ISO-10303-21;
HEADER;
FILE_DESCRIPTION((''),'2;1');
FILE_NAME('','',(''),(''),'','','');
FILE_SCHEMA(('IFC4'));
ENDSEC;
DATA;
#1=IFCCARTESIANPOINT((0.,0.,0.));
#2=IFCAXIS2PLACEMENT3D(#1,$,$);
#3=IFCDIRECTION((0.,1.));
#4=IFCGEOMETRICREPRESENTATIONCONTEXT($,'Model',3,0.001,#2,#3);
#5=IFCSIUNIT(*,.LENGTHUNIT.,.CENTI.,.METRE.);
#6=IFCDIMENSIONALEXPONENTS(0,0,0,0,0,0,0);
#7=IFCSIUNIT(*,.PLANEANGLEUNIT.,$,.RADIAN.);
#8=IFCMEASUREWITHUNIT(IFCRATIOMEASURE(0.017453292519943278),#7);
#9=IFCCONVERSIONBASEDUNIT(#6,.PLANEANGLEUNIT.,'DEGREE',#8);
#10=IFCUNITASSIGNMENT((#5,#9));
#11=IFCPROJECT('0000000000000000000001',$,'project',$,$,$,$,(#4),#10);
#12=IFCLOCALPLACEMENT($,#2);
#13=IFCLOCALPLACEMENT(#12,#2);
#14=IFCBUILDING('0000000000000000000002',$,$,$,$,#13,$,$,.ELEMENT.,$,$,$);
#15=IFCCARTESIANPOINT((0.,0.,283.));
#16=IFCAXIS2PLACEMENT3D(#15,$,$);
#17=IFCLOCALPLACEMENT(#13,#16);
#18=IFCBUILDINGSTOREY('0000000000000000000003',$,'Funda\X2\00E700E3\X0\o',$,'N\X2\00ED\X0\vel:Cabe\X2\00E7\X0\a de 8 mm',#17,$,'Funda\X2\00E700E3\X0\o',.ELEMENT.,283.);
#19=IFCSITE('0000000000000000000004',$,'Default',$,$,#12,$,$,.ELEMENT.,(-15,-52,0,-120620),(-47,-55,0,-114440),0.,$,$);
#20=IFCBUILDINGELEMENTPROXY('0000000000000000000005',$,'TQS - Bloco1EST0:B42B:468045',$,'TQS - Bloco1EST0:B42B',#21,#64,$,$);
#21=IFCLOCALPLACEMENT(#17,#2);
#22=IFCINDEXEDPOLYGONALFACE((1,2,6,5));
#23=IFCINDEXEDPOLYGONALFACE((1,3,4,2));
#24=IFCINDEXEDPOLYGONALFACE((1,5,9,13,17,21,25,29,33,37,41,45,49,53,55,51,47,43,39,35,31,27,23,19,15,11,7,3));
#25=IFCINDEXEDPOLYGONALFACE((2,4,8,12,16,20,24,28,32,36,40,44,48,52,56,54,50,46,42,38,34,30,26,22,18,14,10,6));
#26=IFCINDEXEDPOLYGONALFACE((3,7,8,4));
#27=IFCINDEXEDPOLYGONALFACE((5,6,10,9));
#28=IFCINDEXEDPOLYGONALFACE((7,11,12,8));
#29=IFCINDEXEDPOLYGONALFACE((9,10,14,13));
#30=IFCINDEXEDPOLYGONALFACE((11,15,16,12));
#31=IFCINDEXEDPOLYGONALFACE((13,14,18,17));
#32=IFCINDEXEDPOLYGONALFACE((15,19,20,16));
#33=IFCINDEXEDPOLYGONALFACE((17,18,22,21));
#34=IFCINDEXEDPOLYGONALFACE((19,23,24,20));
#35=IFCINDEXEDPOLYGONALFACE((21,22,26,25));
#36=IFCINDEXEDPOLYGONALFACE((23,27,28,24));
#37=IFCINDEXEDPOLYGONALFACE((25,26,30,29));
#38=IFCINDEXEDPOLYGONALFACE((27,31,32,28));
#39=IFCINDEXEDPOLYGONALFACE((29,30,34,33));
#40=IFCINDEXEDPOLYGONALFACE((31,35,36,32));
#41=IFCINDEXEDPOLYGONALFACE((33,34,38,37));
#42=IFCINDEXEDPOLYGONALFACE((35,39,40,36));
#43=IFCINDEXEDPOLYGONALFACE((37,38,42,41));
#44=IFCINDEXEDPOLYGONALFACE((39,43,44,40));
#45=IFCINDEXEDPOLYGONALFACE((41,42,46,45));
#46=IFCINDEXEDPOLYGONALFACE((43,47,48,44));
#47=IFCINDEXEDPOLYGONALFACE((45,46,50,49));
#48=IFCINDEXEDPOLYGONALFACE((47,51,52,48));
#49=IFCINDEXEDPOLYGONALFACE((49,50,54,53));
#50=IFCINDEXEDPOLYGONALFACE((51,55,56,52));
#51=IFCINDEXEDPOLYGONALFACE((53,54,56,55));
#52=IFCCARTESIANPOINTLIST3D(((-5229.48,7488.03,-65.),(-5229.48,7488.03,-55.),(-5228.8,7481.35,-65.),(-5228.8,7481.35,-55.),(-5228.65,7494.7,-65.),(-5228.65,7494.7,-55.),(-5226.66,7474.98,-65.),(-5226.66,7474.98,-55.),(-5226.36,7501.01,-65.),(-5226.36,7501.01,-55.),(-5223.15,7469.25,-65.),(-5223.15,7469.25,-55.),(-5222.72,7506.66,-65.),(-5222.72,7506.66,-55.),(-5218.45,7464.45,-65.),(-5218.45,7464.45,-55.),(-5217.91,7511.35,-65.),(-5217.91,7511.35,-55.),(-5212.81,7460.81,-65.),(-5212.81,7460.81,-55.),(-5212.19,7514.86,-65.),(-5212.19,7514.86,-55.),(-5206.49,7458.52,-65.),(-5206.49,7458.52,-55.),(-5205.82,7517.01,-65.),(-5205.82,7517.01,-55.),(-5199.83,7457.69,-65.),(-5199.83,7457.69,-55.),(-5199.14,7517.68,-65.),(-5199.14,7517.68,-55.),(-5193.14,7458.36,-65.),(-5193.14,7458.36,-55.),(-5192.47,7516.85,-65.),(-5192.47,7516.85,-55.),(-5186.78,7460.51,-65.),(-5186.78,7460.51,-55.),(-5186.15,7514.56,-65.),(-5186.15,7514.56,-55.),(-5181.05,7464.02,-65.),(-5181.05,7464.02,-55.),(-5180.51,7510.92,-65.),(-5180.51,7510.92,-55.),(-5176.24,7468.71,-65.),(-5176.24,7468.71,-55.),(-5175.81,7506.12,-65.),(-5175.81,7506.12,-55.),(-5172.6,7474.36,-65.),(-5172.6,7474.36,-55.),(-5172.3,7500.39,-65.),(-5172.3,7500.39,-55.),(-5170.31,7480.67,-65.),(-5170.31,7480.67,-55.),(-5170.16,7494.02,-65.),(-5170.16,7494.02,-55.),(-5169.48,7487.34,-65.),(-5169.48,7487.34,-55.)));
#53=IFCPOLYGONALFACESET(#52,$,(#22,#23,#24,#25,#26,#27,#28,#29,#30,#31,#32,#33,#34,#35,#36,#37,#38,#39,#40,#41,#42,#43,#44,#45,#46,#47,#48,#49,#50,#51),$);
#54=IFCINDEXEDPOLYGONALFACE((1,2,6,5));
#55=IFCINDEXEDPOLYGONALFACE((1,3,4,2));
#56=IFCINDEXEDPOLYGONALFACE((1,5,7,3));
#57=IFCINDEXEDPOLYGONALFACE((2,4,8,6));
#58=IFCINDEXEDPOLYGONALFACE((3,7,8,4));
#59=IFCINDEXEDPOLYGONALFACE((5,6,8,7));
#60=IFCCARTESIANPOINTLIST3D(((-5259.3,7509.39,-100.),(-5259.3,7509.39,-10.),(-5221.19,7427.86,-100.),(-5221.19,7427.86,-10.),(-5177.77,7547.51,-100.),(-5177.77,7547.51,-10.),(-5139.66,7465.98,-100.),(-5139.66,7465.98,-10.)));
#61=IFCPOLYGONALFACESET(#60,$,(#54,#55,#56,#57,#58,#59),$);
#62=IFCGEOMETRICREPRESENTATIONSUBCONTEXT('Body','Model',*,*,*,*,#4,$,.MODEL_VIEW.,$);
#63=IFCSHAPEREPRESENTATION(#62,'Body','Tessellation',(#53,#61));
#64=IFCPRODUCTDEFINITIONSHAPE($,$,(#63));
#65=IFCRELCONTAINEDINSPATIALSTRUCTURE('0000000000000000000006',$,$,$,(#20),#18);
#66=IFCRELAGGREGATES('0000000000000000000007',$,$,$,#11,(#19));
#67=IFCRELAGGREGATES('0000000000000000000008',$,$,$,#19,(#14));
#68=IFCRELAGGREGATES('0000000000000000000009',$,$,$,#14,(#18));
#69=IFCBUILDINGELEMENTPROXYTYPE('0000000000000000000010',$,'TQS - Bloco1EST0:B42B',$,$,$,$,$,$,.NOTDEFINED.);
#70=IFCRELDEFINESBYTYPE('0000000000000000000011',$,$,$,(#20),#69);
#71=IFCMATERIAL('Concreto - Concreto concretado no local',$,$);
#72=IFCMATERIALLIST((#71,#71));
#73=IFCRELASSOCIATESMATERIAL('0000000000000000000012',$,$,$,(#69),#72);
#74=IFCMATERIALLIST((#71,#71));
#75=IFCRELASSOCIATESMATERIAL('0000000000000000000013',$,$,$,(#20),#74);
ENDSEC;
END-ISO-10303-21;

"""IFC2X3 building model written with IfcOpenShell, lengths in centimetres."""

from ifc_helpers import new_model, entity, si_unit, converted_unit, direction, frame, frame_2d, origin, origin_2d_with_axis, place, context, subcontext, project, spatial, rectangle, circle, extrude, source, transform, mapped, material, material_list, type_object, type_shapes, element, save


model = new_model("IFC2X3")

# Units and contexts
model_context = context("Model", 3, precision=0.001, world=origin(), true_north=direction((0.0, 1.0)))
body_context = subcontext(model_context, "Body", "Model", "MODEL_VIEW")
ifc_project = project(units=[si_unit("LENGTHUNIT", "METRE", prefix="CENTI"), converted_unit("PLANEANGLEUNIT", "DEGREE", entity("IfcRatioMeasure", 0.017453292519943278), si_unit("PLANEANGLEUNIT", "RADIAN"), dimensions=[0, 0, 0, 0, 0, 0, 0])], contexts=[model_context])

# Site, building, storey
site_placement = place(None, origin())
site = spatial("IfcSite", under=ifc_project, at=site_placement, Name="Default", CompositionType="ELEMENT", RefLatitude=(-15, -52, 0, -120620), RefLongitude=(-47, -55, 0, -114440), RefElevation=0.0)
building_placement = place(site_placement, origin())
building = spatial("IfcBuilding", under=site, at=building_placement, CompositionType="ELEMENT")
storey_placement = place(building_placement, frame((0.0, 0.0, 283.0)))
storey = spatial("IfcBuildingStorey", under=building, at=storey_placement, Name="Fundação", ObjectType="Nível:Cabeça de 8 mm", LongName="Fundação", CompositionType="ELEMENT", Elevation=283.0)

# Building element proxy
ifc_material_1 = material(Name="Concreto - Concreto concretado no local")
ifc_material_list_1 = material_list([ifc_material_1, ifc_material_1])
ifc_material_list_2 = material_list([ifc_material_1, ifc_material_1])
building_element_proxy_type_1 = type_object("IfcBuildingElementProxyType", Name="TQS - Bloco1EST0:B42B", PredefinedType="NOTDEFINED", material=ifc_material_list_2)
shared_shape_1 = source(origin(), body_context, "Body", "SweptSolid", [
    extrude(circle(Radius=30.0, at=frame_2d((0.0, 0.0), x_axis=(1.0, 0.0))), frame((0.0, 0.0, -55.0)), (0.0, 0.0, 1.0), 10.0),
    extrude(rectangle(XDim=90.0, YDim=90.0, at=origin_2d_with_axis()), frame((0.0, 0.0, -90.0), z_axis=(0.0, 0.0, 1.0), x_axis=(-1.0, 0.0, 0.0)), (0.0, 0.0, 1.0), 90.0),
])
type_shapes(building_element_proxy_type_1, [shared_shape_1])
proxy_1_placement = place(storey_placement, frame((-5199.48, 7487.68, -10.0), z_axis=(0.0, 0.0, 1.0), x_axis=(0.905902, 0.423488, 0.0)))
element("IfcBuildingElementProxy", 1, at=proxy_1_placement, inside=storey, type_object=building_element_proxy_type_1, material=ifc_material_list_1, Name="TQS - Bloco1EST0:B42B:468045", ObjectType="TQS - Bloco1EST0:B42B", context=body_context, shape_type="MappedRepresentation", body=[
    mapped(shared_shape_1, transform((0.0, 0.0, 0.0), scale=1.0)),
])

save(model, "model.ifc")
